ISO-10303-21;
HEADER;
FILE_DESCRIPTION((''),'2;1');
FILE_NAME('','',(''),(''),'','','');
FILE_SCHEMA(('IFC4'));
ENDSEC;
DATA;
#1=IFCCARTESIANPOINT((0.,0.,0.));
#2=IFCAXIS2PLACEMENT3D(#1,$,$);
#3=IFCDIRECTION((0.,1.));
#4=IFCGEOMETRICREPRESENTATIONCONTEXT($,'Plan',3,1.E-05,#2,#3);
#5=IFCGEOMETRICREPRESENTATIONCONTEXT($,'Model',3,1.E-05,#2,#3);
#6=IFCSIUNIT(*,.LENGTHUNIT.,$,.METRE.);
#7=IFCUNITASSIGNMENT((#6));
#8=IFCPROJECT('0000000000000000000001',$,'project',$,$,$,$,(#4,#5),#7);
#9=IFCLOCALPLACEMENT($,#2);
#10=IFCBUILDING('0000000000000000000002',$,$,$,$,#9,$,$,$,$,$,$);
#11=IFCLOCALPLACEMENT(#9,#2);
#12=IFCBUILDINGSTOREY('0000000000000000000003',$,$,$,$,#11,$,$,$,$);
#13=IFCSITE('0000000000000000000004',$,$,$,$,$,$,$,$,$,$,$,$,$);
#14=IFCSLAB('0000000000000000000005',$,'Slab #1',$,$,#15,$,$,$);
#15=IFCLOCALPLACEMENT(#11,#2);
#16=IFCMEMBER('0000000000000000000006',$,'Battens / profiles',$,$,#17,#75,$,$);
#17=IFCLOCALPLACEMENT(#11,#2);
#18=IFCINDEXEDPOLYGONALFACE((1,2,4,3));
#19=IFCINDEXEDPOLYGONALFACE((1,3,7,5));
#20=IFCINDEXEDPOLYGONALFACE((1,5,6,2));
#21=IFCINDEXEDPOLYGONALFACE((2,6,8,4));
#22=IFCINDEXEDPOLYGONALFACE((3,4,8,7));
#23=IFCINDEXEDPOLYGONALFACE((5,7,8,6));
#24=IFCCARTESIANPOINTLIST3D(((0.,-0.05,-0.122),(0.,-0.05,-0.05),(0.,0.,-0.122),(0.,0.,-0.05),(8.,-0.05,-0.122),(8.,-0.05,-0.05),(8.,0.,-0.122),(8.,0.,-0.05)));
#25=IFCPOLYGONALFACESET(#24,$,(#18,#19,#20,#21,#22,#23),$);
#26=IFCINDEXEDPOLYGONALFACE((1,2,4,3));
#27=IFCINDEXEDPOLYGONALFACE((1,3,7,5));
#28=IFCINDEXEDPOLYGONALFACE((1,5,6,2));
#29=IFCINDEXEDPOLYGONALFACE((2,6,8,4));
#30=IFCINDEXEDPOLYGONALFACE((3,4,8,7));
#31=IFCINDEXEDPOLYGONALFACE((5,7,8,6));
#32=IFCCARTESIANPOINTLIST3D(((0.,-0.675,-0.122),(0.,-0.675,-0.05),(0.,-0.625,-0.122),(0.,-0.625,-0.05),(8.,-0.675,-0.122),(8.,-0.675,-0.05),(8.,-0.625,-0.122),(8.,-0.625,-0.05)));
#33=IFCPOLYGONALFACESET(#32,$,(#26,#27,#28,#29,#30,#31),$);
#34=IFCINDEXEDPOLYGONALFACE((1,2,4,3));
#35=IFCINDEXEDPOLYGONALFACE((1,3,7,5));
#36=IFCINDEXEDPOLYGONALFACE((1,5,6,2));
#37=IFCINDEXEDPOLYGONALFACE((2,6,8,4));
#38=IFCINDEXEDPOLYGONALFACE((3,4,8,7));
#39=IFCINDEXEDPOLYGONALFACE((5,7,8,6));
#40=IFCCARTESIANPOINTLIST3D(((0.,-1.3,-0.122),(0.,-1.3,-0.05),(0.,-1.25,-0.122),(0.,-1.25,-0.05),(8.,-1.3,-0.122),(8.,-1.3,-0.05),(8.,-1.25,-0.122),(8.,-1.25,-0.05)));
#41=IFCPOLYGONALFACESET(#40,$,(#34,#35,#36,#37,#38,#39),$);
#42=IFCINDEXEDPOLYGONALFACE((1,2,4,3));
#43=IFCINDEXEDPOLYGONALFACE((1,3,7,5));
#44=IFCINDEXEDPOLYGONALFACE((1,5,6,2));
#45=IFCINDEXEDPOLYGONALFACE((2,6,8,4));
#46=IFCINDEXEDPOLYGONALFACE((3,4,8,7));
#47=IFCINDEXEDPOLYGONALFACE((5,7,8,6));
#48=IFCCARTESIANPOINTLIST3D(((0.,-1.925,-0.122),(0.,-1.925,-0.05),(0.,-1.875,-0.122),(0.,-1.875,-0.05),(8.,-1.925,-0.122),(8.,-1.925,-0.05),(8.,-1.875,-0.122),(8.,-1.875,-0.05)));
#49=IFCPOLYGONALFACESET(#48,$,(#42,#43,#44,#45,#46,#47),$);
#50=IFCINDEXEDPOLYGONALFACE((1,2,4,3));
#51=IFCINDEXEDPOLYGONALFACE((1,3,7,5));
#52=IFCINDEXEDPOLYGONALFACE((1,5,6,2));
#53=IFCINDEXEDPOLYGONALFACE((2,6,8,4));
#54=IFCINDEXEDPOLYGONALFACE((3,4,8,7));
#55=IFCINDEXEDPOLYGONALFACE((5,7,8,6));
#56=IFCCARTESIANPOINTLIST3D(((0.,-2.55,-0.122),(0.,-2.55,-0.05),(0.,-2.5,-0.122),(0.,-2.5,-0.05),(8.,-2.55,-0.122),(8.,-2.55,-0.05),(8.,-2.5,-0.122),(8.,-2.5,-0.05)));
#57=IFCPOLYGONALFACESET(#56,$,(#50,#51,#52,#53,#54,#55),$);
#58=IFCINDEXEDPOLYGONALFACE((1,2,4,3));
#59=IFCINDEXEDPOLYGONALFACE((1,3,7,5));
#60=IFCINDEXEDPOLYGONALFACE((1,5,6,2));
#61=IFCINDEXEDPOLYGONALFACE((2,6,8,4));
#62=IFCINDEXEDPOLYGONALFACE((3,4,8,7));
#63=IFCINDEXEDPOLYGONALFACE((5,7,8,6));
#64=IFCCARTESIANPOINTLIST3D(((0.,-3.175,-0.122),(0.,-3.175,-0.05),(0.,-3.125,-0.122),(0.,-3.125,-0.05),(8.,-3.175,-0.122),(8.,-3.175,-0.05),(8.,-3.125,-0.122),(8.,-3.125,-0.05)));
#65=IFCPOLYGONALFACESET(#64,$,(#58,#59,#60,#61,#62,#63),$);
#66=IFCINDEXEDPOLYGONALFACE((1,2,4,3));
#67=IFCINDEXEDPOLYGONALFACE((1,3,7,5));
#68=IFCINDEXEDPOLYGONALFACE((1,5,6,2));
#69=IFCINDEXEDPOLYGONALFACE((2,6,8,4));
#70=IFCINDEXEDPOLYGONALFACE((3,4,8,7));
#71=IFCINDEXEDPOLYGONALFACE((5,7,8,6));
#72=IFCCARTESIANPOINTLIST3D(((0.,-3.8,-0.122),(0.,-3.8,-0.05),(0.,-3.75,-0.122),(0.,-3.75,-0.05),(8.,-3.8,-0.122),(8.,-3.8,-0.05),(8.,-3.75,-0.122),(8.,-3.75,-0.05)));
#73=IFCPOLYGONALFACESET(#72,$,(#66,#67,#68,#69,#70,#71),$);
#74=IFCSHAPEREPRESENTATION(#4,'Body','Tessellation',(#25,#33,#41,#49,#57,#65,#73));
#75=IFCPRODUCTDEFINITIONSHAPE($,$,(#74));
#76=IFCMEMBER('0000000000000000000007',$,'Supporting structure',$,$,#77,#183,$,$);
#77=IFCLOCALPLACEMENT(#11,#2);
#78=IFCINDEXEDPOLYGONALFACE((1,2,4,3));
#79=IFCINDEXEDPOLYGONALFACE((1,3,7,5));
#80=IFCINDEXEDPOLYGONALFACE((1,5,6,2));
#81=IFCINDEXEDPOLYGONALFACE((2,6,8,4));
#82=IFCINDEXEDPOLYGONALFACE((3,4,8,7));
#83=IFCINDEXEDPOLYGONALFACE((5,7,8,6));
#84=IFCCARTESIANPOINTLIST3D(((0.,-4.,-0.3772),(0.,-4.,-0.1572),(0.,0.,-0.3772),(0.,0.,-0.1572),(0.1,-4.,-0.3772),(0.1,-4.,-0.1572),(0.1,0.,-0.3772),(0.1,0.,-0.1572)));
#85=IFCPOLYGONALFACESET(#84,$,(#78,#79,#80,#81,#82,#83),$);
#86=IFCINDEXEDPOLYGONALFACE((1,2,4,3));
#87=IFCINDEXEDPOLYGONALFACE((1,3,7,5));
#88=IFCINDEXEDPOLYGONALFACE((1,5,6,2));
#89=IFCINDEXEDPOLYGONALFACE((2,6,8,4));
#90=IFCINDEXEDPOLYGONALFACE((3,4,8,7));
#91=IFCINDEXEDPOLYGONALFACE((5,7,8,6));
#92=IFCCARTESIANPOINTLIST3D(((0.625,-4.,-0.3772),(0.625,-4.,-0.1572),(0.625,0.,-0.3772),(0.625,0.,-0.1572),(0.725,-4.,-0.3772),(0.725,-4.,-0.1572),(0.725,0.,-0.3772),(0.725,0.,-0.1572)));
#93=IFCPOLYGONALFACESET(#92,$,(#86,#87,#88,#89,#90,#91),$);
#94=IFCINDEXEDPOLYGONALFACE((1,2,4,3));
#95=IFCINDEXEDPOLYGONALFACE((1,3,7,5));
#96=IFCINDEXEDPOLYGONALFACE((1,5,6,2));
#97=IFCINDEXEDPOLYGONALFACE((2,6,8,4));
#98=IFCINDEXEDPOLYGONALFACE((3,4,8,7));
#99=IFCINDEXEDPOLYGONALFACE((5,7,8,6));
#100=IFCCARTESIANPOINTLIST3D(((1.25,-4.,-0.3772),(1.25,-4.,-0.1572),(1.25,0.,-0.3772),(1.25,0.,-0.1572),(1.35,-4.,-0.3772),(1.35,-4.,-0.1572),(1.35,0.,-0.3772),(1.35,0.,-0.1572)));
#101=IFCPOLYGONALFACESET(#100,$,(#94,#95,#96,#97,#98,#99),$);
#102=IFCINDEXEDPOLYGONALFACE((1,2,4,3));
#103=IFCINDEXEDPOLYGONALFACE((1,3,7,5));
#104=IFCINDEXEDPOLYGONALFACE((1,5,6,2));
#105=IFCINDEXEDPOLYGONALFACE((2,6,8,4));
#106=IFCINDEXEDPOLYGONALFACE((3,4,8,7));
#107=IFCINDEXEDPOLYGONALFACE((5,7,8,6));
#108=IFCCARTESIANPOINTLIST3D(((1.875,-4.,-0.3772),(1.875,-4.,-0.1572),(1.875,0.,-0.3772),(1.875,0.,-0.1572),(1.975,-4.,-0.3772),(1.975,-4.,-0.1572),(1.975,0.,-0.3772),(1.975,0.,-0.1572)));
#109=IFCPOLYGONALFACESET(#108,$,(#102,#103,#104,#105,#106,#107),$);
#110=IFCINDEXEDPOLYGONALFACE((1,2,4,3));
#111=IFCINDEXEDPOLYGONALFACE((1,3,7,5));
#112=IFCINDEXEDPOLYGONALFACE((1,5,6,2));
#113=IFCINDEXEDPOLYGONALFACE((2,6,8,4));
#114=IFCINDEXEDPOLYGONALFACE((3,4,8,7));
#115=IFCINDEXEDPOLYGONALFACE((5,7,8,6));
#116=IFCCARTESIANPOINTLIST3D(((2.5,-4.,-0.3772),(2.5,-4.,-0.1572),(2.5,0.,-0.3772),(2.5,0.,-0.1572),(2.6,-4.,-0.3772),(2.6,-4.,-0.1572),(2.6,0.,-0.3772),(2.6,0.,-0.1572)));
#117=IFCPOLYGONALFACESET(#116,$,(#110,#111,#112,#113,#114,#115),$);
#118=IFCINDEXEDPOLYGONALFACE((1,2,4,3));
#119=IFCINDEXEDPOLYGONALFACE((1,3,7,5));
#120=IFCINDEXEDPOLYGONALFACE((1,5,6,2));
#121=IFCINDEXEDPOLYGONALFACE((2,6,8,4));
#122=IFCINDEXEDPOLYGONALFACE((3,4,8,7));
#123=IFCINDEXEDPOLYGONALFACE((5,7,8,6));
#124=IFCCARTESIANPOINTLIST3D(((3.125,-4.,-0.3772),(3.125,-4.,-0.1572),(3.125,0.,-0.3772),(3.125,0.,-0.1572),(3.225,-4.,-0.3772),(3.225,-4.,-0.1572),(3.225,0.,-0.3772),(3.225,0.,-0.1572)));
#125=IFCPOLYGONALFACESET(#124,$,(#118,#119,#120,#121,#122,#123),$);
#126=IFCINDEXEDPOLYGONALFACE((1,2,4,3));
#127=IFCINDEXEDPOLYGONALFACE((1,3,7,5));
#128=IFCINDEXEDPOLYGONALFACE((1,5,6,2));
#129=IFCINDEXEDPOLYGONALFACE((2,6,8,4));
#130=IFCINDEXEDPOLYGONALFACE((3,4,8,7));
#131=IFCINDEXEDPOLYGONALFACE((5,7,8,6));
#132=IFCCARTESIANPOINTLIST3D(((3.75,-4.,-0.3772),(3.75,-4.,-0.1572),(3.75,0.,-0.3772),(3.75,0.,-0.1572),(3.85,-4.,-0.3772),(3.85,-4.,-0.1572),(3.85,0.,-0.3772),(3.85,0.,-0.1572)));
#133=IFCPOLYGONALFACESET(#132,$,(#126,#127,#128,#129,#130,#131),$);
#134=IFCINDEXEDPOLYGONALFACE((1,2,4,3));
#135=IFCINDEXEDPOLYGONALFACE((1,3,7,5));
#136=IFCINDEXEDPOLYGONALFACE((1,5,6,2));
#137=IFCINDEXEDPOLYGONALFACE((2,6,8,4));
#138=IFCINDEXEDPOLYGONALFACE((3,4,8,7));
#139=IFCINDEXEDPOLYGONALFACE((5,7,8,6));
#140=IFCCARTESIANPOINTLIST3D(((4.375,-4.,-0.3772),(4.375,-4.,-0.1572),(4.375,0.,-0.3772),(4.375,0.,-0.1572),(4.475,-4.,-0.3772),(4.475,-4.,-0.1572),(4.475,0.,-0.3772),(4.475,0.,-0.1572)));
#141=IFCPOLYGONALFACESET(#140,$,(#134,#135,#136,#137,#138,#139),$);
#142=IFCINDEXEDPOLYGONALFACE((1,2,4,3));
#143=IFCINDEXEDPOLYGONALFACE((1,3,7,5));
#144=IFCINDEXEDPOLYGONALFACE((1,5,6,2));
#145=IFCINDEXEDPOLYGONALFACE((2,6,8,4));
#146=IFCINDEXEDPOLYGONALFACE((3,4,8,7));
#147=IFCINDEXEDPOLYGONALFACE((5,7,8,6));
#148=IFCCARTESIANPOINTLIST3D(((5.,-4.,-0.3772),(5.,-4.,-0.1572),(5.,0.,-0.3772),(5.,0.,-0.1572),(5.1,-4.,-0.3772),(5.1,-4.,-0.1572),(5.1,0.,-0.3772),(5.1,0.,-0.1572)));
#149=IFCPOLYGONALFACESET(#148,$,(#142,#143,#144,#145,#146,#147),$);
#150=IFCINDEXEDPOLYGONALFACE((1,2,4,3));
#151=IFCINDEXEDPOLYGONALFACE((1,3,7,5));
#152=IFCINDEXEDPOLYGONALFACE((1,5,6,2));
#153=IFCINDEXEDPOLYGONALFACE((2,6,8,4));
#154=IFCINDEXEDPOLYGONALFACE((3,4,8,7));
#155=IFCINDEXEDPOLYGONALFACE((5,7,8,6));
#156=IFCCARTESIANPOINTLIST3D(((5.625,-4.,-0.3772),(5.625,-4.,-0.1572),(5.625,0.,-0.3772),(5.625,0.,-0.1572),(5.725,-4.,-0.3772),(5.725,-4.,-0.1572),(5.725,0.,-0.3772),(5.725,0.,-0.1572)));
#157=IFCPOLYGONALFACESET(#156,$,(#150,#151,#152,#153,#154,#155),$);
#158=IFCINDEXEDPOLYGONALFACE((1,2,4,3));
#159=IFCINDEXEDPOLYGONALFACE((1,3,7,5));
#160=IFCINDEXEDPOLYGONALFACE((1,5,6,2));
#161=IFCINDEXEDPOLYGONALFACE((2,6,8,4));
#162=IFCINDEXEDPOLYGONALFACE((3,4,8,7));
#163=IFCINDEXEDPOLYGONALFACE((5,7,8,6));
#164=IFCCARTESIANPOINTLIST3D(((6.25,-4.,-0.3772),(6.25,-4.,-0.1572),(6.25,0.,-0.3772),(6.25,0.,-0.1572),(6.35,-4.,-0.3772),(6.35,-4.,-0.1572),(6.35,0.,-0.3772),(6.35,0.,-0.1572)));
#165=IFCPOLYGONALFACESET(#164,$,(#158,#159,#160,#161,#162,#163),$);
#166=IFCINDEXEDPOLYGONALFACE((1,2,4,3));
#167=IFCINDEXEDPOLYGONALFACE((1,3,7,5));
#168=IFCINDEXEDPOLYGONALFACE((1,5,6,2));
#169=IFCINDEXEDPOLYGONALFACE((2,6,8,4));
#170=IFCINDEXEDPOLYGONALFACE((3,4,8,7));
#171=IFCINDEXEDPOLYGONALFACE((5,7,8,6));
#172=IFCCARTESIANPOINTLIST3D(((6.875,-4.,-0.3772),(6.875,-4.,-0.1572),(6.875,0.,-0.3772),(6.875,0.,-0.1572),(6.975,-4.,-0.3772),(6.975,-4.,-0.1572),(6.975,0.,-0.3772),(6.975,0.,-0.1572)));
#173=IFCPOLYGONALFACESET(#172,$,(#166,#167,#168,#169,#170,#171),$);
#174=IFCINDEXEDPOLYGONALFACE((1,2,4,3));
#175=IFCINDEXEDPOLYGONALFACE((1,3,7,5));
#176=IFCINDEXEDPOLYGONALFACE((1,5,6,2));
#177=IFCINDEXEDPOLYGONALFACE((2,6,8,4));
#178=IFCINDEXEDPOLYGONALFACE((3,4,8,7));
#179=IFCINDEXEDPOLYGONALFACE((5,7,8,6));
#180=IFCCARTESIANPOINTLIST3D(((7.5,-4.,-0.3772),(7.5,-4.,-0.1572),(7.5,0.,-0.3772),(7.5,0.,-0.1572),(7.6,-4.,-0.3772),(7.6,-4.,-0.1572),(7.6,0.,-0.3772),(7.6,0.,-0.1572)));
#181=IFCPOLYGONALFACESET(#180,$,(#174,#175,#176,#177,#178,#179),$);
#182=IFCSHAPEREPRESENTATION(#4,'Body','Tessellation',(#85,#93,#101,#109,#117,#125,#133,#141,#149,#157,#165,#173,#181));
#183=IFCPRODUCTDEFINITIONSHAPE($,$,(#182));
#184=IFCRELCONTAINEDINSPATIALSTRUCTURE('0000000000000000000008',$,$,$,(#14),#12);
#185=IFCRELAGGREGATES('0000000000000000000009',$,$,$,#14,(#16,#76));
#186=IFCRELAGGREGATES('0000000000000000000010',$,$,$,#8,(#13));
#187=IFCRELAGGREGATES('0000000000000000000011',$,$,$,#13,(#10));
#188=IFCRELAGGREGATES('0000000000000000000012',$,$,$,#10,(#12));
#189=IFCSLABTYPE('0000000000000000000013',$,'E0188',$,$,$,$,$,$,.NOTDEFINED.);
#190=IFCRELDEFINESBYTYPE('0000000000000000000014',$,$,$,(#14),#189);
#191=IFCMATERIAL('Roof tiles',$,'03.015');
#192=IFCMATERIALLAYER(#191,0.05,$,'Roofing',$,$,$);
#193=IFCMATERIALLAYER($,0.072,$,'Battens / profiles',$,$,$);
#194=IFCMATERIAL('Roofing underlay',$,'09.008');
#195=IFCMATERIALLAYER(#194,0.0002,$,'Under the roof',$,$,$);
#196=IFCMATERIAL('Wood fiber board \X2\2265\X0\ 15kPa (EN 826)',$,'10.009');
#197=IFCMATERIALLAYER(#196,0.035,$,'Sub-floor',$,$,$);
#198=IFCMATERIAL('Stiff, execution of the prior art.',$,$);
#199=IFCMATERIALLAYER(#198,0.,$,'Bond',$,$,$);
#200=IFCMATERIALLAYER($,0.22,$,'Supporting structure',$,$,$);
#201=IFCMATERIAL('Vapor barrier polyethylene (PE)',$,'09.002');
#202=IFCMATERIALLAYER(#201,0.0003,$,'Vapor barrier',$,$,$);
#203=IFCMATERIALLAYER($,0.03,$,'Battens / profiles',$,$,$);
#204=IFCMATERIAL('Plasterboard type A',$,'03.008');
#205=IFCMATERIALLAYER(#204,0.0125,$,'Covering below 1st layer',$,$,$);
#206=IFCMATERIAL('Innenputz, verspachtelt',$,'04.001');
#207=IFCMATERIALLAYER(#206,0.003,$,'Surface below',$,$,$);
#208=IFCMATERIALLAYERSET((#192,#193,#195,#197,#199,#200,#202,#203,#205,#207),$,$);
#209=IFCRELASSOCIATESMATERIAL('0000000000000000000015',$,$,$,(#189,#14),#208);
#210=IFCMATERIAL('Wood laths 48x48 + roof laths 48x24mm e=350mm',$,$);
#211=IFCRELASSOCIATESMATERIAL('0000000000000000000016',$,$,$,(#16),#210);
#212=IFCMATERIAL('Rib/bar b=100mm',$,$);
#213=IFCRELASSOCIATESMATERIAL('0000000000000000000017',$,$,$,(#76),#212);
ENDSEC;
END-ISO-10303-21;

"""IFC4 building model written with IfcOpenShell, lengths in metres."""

from ifc_helpers import new_model, si_unit, direction, frame, frame_2d, origin, place, context, project, spatial, rectangle, extrude, material, layer, layer_set, type_object, element, aggregate, save


model = new_model("IFC4")

# Units and contexts
plan_context = context("Plan", 3, precision=1e-05, world=origin(), true_north=direction((0.0, 1.0)))
model_context = context("Model", 3, precision=1e-05, world=origin(), true_north=direction((0.0, 1.0)))
ifc_project = project(units=[si_unit("LENGTHUNIT", "METRE")], contexts=[plan_context, model_context])

# Site, building, storey
site = spatial("IfcSite", under=ifc_project)
building_placement = place(None, origin())
building = spatial("IfcBuilding", under=site, at=building_placement)
storey_placement = place(building_placement, origin())
storey = spatial("IfcBuildingStorey", under=building, at=storey_placement)

# Slab, members
ifc_material_1 = material(Name="Roof tiles", Category="03.015")
ifc_layer_1 = layer(ifc_material_1, 0.05, Name="Roofing")
ifc_layer_2 = layer(None, 0.072, Name="Battens / profiles")
ifc_material_2 = material(Name="Roofing underlay", Category="09.008")
ifc_layer_3 = layer(ifc_material_2, 0.0002, Name="Under the roof")
ifc_material_3 = material(Name="Wood fiber board ≥ 15kPa (EN 826)", Category="10.009")
ifc_layer_4 = layer(ifc_material_3, 0.035, Name="Sub-floor")
ifc_material_4 = material(Name="Stiff, execution of the prior art.")
ifc_layer_5 = layer(ifc_material_4, 0.0, Name="Bond")
ifc_layer_6 = layer(None, 0.22, Name="Supporting structure")
ifc_material_5 = material(Name="Vapor barrier polyethylene (PE)", Category="09.002")
ifc_layer_7 = layer(ifc_material_5, 0.0003, Name="Vapor barrier")
ifc_layer_8 = layer(None, 0.03, Name="Battens / profiles")
ifc_material_6 = material(Name="Plasterboard type A", Category="03.008")
ifc_layer_9 = layer(ifc_material_6, 0.0125, Name="Covering below 1st layer")
ifc_material_7 = material(Name="Innenputz, verspachtelt", Category="04.001")
ifc_layer_10 = layer(ifc_material_7, 0.003, Name="Surface below")
ifc_layer_set = layer_set([ifc_layer_1, ifc_layer_2, ifc_layer_3, ifc_layer_4, ifc_layer_5, ifc_layer_6, ifc_layer_7, ifc_layer_8, ifc_layer_9, ifc_layer_10])
slab_type = type_object("IfcSlabType", Name="E0188", PredefinedType="NOTDEFINED", material=ifc_layer_set)
slab_placement = place(None, frame((0.0, 0.0, 0.0), z_axis=(0.0, 0.0, -1.0), x_axis=(1.0, 0.0, 0.0)))
slab = element("IfcSlab", 1, at=slab_placement, inside=storey, type_object=slab_type, material=ifc_layer_set, Name="Slab #1")
ifc_material_8 = material(Name="Wood laths 48x48 + roof laths 48x24mm e=350mm")
member_1_placement = place(slab_placement, origin())
member_1 = element("IfcMember", 2, at=member_1_placement, material=ifc_material_8, Name="Battens / profiles", context=plan_context, shape_type="SweptSolid", body=[
    extrude(rectangle(XDim=0.05, YDim=0.072, at=frame_2d((0.025, 0.036), x_axis=(1.0, 0.0))), frame((0.0, 0.0, 0.05), z_axis=(1.0, 0.0, 0.0), x_axis=(0.0, 1.0, 0.0)), (0.0, 0.0, 1.0), 8.0),
    extrude(rectangle(XDim=0.05, YDim=0.072, at=frame_2d((0.025, 0.036), x_axis=(1.0, 0.0))), frame((0.0, 0.625, 0.05), z_axis=(1.0, 0.0, 0.0), x_axis=(0.0, 1.0, 0.0)), (0.0, 0.0, 1.0), 8.0),
    extrude(rectangle(XDim=0.05, YDim=0.072, at=frame_2d((0.025, 0.036), x_axis=(1.0, 0.0))), frame((0.0, 1.25, 0.05), z_axis=(1.0, 0.0, 0.0), x_axis=(0.0, 1.0, 0.0)), (0.0, 0.0, 1.0), 8.0),
    extrude(rectangle(XDim=0.05, YDim=0.072, at=frame_2d((0.025, 0.036), x_axis=(1.0, 0.0))), frame((0.0, 1.875, 0.05), z_axis=(1.0, 0.0, 0.0), x_axis=(0.0, 1.0, 0.0)), (0.0, 0.0, 1.0), 8.0),
    extrude(rectangle(XDim=0.05, YDim=0.072, at=frame_2d((0.025, 0.036), x_axis=(1.0, 0.0))), frame((0.0, 2.5, 0.05), z_axis=(1.0, 0.0, 0.0), x_axis=(0.0, 1.0, 0.0)), (0.0, 0.0, 1.0), 8.0),
    extrude(rectangle(XDim=0.05, YDim=0.072, at=frame_2d((0.025, 0.036), x_axis=(1.0, 0.0))), frame((0.0, 3.125, 0.05), z_axis=(1.0, 0.0, 0.0), x_axis=(0.0, 1.0, 0.0)), (0.0, 0.0, 1.0), 8.0),
    extrude(rectangle(XDim=0.05, YDim=0.072, at=frame_2d((0.025, 0.036), x_axis=(1.0, 0.0))), frame((0.0, 3.75, 0.05), z_axis=(1.0, 0.0, 0.0), x_axis=(0.0, 1.0, 0.0)), (0.0, 0.0, 1.0), 8.0),
])
ifc_material_9 = material(Name="Rib/bar b=100mm")
member_2_placement = place(slab_placement, origin())
member_2 = element("IfcMember", 3, at=member_2_placement, material=ifc_material_9, Name="Supporting structure", context=plan_context, shape_type="SweptSolid", body=[
    extrude(rectangle(XDim=0.1, YDim=0.22, at=frame_2d((0.05, 0.11), x_axis=(1.0, 0.0))), frame((0.0, 4.0, 0.1572), z_axis=(0.0, -1.0, 0.0), x_axis=(1.0, 0.0, 0.0)), (0.0, 0.0, 1.0), 4.0),
    extrude(rectangle(XDim=0.1, YDim=0.22, at=frame_2d((0.05, 0.11), x_axis=(1.0, 0.0))), frame((0.625, 4.0, 0.1572), z_axis=(0.0, -1.0, 0.0), x_axis=(1.0, 0.0, 0.0)), (0.0, 0.0, 1.0), 4.0),
    extrude(rectangle(XDim=0.1, YDim=0.22, at=frame_2d((0.05, 0.11), x_axis=(1.0, 0.0))), frame((1.25, 4.0, 0.1572), z_axis=(0.0, -1.0, 0.0), x_axis=(1.0, 0.0, 0.0)), (0.0, 0.0, 1.0), 4.0),
    extrude(rectangle(XDim=0.1, YDim=0.22, at=frame_2d((0.05, 0.11), x_axis=(1.0, 0.0))), frame((1.875, 4.0, 0.1572), z_axis=(0.0, -1.0, 0.0), x_axis=(1.0, 0.0, 0.0)), (0.0, 0.0, 1.0), 4.0),
    extrude(rectangle(XDim=0.1, YDim=0.22, at=frame_2d((0.05, 0.11), x_axis=(1.0, 0.0))), frame((2.5, 4.0, 0.1572), z_axis=(0.0, -1.0, 0.0), x_axis=(1.0, 0.0, 0.0)), (0.0, 0.0, 1.0), 4.0),
    extrude(rectangle(XDim=0.1, YDim=0.22, at=frame_2d((0.05, 0.11), x_axis=(1.0, 0.0))), frame((3.125, 4.0, 0.1572), z_axis=(0.0, -1.0, 0.0), x_axis=(1.0, 0.0, 0.0)), (0.0, 0.0, 1.0), 4.0),
    extrude(rectangle(XDim=0.1, YDim=0.22, at=frame_2d((0.05, 0.11), x_axis=(1.0, 0.0))), frame((3.75, 4.0, 0.1572), z_axis=(0.0, -1.0, 0.0), x_axis=(1.0, 0.0, 0.0)), (0.0, 0.0, 1.0), 4.0),
    extrude(rectangle(XDim=0.1, YDim=0.22, at=frame_2d((0.05, 0.11), x_axis=(1.0, 0.0))), frame((4.375, 4.0, 0.1572), z_axis=(0.0, -1.0, 0.0), x_axis=(1.0, 0.0, 0.0)), (0.0, 0.0, 1.0), 4.0),
    extrude(rectangle(XDim=0.1, YDim=0.22, at=frame_2d((0.05, 0.11), x_axis=(1.0, 0.0))), frame((5.0, 4.0, 0.1572), z_axis=(0.0, -1.0, 0.0), x_axis=(1.0, 0.0, 0.0)), (0.0, 0.0, 1.0), 4.0),
    extrude(rectangle(XDim=0.1, YDim=0.22, at=frame_2d((0.05, 0.11), x_axis=(1.0, 0.0))), frame((5.625, 4.0, 0.1572), z_axis=(0.0, -1.0, 0.0), x_axis=(1.0, 0.0, 0.0)), (0.0, 0.0, 1.0), 4.0),
    extrude(rectangle(XDim=0.1, YDim=0.22, at=frame_2d((0.05, 0.11), x_axis=(1.0, 0.0))), frame((6.25, 4.0, 0.1572), z_axis=(0.0, -1.0, 0.0), x_axis=(1.0, 0.0, 0.0)), (0.0, 0.0, 1.0), 4.0),
    extrude(rectangle(XDim=0.1, YDim=0.22, at=frame_2d((0.05, 0.11), x_axis=(1.0, 0.0))), frame((6.875, 4.0, 0.1572), z_axis=(0.0, -1.0, 0.0), x_axis=(1.0, 0.0, 0.0)), (0.0, 0.0, 1.0), 4.0),
    extrude(rectangle(XDim=0.1, YDim=0.22, at=frame_2d((0.05, 0.11), x_axis=(1.0, 0.0))), frame((7.5, 4.0, 0.1572), z_axis=(0.0, -1.0, 0.0), x_axis=(1.0, 0.0, 0.0)), (0.0, 0.0, 1.0), 4.0),
])
aggregate(slab, [member_1, member_2])

save(model, "model.ifc")
